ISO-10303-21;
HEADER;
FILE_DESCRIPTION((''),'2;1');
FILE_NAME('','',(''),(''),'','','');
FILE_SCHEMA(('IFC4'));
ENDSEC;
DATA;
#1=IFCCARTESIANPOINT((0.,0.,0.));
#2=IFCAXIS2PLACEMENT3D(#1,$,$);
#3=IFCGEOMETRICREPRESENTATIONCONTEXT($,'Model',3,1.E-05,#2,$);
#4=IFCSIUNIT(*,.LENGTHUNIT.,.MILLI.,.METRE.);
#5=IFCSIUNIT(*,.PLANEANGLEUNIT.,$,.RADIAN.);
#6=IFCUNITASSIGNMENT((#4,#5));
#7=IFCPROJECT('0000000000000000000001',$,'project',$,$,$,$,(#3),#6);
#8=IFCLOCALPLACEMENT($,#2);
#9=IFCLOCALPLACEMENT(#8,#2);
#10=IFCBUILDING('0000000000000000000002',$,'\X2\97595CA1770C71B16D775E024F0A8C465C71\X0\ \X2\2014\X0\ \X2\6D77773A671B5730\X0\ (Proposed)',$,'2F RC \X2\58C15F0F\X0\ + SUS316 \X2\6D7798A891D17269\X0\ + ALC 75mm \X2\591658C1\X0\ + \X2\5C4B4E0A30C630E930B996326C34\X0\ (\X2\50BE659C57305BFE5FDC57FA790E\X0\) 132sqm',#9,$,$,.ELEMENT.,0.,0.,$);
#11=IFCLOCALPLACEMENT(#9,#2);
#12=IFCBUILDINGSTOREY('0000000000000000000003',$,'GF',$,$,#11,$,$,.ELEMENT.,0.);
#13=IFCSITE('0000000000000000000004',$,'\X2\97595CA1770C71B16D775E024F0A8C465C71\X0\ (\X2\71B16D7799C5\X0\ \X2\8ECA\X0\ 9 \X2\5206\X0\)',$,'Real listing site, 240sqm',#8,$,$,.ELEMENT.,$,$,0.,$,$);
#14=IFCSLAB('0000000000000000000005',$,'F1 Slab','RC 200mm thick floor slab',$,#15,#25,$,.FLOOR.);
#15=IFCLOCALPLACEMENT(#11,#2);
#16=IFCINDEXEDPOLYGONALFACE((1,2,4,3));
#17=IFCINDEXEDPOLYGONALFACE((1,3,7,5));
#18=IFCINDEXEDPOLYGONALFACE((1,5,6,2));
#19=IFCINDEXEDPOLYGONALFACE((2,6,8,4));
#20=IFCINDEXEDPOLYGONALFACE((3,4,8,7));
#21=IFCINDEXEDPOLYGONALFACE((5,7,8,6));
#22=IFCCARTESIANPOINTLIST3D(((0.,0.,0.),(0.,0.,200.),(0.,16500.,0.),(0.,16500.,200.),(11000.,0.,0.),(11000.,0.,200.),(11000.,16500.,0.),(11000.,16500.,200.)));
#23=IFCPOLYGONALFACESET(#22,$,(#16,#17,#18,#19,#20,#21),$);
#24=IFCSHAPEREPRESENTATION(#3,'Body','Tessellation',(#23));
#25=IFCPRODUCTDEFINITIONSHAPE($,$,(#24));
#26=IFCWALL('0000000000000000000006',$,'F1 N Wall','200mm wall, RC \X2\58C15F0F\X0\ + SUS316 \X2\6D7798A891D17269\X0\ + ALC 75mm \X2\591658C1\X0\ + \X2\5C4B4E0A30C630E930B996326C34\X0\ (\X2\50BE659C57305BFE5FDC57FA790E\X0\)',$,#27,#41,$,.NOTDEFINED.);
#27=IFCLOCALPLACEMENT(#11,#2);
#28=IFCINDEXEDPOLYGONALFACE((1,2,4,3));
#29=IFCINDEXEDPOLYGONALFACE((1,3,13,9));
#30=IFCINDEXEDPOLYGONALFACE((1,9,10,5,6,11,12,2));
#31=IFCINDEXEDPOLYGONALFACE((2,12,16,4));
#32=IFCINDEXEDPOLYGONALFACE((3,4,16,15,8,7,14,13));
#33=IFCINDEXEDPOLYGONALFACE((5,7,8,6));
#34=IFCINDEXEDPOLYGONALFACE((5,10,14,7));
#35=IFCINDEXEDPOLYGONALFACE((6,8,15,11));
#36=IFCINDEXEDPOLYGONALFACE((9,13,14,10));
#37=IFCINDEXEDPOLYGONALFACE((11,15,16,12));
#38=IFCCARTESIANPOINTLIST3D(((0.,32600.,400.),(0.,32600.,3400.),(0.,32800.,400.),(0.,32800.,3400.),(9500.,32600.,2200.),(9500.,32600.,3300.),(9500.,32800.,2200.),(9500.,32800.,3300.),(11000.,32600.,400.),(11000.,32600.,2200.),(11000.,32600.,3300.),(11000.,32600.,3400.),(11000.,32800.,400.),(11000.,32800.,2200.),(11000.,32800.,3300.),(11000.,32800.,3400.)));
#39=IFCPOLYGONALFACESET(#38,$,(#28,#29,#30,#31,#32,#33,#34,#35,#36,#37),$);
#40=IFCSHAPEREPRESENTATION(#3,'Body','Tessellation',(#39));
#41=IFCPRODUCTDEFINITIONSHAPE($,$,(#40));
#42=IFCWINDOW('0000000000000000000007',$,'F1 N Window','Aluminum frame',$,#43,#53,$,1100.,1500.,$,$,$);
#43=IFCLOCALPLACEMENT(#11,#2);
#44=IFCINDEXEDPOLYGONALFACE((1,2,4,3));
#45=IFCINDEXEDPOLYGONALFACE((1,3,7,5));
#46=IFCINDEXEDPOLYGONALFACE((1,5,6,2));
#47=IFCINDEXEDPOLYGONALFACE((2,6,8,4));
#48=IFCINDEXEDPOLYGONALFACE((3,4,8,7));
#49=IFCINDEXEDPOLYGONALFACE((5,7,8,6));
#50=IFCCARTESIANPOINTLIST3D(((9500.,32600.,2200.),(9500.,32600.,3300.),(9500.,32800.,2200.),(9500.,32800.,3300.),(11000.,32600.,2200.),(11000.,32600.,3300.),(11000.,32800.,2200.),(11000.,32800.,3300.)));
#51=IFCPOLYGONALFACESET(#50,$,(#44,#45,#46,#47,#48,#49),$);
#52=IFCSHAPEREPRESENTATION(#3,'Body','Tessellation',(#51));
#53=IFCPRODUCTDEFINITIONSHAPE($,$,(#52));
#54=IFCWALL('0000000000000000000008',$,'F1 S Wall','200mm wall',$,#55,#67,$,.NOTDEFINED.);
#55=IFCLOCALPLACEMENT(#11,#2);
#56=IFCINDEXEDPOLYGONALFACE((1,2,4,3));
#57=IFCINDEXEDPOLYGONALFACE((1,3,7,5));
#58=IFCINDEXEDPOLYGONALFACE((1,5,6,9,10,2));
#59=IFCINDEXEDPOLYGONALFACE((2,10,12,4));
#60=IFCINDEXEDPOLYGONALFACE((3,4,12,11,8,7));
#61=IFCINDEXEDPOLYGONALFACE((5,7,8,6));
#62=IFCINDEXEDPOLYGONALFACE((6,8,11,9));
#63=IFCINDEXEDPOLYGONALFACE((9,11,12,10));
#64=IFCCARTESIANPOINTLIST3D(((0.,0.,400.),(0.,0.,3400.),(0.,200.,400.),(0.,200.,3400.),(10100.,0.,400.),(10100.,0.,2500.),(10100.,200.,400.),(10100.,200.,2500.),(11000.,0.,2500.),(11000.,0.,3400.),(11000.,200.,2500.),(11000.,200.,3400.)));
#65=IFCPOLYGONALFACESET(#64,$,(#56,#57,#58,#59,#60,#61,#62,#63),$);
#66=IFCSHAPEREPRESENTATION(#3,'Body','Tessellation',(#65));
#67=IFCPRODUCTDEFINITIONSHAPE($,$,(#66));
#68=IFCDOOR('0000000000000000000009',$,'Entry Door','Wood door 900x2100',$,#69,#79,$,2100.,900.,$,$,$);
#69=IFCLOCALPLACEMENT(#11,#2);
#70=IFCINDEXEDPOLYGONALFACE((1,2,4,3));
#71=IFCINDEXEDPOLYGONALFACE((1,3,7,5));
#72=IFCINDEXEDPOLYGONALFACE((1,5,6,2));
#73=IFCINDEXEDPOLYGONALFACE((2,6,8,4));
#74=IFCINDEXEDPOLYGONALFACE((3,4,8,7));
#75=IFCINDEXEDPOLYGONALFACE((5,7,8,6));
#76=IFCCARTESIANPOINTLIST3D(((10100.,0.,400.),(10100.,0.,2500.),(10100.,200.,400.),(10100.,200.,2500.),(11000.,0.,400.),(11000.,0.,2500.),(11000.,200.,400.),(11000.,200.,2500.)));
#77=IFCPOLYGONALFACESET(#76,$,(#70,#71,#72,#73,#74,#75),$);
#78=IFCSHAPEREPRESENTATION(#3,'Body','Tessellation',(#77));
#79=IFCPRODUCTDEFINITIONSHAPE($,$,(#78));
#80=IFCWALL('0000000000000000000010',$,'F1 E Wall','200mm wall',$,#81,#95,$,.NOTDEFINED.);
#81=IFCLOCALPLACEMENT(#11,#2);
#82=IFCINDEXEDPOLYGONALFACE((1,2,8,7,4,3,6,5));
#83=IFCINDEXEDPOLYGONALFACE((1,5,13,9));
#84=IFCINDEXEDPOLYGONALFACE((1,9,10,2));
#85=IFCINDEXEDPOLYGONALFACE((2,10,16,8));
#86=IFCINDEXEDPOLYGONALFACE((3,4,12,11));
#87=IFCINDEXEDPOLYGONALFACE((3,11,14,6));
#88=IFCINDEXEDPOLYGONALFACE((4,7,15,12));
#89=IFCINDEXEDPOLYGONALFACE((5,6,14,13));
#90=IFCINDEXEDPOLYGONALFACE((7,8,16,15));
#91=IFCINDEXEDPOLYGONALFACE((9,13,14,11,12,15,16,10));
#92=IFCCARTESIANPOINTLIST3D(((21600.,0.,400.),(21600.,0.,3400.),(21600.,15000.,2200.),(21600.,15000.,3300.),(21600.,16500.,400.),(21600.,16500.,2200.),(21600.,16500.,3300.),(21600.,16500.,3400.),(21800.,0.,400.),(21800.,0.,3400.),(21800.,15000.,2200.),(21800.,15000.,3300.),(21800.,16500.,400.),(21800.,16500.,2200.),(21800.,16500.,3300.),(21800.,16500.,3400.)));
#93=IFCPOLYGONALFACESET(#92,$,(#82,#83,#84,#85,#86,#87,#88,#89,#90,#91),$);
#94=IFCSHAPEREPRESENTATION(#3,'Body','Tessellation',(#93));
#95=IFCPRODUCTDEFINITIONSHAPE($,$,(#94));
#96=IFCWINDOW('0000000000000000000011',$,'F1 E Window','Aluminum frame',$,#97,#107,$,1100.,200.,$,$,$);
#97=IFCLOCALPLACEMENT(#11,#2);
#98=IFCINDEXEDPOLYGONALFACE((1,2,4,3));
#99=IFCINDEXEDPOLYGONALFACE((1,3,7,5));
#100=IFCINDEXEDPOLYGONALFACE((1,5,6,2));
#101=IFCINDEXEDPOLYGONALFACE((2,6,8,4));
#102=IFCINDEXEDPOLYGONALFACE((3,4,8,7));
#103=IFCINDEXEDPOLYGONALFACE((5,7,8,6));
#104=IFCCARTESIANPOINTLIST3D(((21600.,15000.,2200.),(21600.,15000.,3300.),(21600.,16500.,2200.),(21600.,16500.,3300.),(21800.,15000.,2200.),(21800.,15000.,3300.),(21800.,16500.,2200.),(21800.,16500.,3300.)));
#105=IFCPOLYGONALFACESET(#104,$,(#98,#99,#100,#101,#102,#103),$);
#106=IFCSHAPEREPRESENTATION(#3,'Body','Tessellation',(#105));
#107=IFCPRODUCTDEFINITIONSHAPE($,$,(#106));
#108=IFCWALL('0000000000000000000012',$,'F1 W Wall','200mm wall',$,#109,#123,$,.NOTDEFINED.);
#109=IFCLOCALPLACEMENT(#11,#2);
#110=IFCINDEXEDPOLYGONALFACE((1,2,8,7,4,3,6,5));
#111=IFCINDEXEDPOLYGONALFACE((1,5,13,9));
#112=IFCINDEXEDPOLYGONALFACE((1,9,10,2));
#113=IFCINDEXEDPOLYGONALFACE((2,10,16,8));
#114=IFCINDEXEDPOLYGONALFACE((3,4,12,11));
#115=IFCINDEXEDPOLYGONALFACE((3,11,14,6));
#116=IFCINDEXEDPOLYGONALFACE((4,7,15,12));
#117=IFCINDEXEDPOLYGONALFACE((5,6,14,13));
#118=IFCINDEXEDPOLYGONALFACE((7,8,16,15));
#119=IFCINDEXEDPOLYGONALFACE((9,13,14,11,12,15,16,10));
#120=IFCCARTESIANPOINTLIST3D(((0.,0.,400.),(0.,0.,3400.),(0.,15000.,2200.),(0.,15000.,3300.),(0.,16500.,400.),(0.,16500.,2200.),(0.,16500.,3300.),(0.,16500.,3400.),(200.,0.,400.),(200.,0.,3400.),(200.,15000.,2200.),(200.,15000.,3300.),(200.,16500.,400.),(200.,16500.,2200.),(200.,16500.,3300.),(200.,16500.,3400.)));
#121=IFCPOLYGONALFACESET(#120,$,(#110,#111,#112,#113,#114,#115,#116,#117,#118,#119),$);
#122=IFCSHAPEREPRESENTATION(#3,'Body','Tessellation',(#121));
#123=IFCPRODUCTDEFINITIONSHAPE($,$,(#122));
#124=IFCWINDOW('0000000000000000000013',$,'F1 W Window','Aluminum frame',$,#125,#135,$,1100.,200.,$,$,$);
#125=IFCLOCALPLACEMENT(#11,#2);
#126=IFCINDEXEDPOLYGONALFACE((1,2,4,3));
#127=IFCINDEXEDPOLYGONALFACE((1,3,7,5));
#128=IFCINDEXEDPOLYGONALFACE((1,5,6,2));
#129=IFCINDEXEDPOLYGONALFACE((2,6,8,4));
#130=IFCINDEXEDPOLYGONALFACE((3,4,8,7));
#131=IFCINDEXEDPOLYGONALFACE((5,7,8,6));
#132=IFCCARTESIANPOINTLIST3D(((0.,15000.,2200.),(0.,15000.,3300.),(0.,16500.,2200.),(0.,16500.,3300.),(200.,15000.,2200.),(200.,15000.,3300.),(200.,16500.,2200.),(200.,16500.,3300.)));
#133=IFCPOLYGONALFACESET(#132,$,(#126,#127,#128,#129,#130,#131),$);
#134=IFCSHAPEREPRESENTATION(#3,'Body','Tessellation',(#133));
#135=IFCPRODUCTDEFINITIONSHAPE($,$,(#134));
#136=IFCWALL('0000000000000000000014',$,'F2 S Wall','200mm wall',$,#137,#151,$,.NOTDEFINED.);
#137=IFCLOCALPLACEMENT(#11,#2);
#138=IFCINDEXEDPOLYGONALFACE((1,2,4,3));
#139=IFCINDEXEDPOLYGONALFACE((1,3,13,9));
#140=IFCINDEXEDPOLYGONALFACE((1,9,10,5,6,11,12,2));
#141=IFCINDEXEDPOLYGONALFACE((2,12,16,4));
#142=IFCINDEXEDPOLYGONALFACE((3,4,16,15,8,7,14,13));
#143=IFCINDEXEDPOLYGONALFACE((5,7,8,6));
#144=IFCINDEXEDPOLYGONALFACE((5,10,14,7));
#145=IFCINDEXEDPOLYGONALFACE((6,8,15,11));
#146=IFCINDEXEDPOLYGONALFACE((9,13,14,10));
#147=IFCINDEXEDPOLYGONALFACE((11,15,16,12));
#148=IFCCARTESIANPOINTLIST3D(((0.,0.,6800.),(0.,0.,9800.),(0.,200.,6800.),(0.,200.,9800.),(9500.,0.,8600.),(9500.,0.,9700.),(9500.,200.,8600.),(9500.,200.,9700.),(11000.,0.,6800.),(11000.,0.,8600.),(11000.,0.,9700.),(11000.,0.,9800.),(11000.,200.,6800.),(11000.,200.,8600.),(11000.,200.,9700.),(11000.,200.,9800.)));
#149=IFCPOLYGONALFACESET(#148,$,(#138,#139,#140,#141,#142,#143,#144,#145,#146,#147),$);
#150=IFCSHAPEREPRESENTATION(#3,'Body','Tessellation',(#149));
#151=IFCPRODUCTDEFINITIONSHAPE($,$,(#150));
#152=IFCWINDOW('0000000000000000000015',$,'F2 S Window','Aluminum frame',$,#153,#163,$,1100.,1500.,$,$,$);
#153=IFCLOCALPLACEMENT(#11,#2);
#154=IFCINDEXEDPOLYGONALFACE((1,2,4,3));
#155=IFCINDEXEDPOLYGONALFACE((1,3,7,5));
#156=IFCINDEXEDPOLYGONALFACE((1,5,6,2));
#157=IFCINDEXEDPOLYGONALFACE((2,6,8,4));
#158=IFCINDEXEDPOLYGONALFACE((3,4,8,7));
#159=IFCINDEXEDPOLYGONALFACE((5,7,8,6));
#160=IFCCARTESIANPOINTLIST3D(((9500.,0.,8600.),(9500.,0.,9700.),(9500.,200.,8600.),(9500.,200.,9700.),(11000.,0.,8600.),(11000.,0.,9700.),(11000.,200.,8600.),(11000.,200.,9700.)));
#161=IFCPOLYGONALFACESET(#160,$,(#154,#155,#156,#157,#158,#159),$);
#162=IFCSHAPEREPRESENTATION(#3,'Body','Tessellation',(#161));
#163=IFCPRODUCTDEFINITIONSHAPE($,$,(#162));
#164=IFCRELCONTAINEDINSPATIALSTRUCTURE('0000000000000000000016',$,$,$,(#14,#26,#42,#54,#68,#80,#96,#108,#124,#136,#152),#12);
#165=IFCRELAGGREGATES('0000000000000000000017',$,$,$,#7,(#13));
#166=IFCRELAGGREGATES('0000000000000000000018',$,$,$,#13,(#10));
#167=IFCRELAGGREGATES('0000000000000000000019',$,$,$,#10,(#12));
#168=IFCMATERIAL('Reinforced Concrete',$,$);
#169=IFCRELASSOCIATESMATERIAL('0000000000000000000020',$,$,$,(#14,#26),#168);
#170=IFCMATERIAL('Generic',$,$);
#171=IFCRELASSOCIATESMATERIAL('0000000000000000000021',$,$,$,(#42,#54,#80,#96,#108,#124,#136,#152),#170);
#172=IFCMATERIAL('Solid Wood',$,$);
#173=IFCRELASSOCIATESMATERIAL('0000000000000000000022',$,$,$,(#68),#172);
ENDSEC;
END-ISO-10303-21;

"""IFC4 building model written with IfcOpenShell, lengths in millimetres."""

from ifc_helpers import new_model, si_unit, frame, frame_2d, origin, place, context, project, spatial, rectangle, extrude, material, element, fill, save


model = new_model("IFC4")

# Units and contexts
model_context = context("Model", 3, precision=1e-05, world=origin())
ifc_project = project(units=[si_unit("LENGTHUNIT", "METRE", prefix="MILLI"), si_unit("PLANEANGLEUNIT", "RADIAN")], contexts=[model_context])

# Site, building, storey
site_placement = place(None, origin())
site = spatial("IfcSite", under=ifc_project, at=site_placement, Name="静岡県熱海市伊豆山 (熱海駅 車 9 分)", ObjectType="Real listing site, 240sqm", CompositionType="ELEMENT", RefElevation=0.0)
building_placement = place(site_placement, origin())
building = spatial("IfcBuilding", under=site, at=building_placement, Name="静岡県熱海市伊豆山 — 海眺望地 (Proposed)", ObjectType="2F RC 壁式 + SUS316 海風金物 + ALC 75mm 外壁 + 屋上テラス防水 (傾斜地対応基礎) 132sqm", CompositionType="ELEMENT", ElevationOfRefHeight=0.0, ElevationOfTerrain=0.0)
storey_placement = place(building_placement, origin())
storey = spatial("IfcBuildingStorey", under=building, at=storey_placement, Name="GF", CompositionType="ELEMENT", Elevation=0.0)

# Slab
ifc_material_1 = material(Name="Reinforced Concrete")
slab_1_placement = place(storey_placement, origin())
element("IfcSlab", 1, at=slab_1_placement, inside=storey, material=ifc_material_1, Name="F1 Slab", Description="RC 200mm thick floor slab", PredefinedType="FLOOR", context=model_context, shape_type="SweptSolid", body=[
    extrude(rectangle(XDim=11000.0, YDim=16500.0, at=frame_2d((5500.0, 8250.0))), origin(), (0.0, 0.0, 1.0), 200.0),
])

# Wall, opening, window
wall_1_placement = place(storey_placement, frame((0.0, 16300.0, 200.0)))
wall_1 = element("IfcWall", 2, at=wall_1_placement, inside=storey, material=ifc_material_1, Name="F1 N Wall", Description="200mm wall, RC 壁式 + SUS316 海風金物 + ALC 75mm 外壁 + 屋上テラス防水 (傾斜地対応基礎)", PredefinedType="NOTDEFINED", context=model_context, shape_type="SweptSolid", body=[
    extrude(rectangle(XDim=11000.0, YDim=200.0, at=frame_2d((5500.0, 100.0))), frame((0.0, 16300.0, 200.0)), (0.0, 0.0, 1.0), 3000.0),
])
opening_1_placement = place(storey_placement, frame((4750.0, 16300.0, 1100.0)))
opening_1 = element("IfcOpeningElement", 3, at=opening_1_placement, cuts=wall_1, PredefinedType="NOTDEFINED", context=model_context, shape_type="SweptSolid", body=[
    extrude(rectangle(XDim=1500.0, YDim=200.0, at=frame_2d((750.0, 100.0))), frame((4750.0, 16300.0, 1100.0)), (0.0, 0.0, 1.0), 1100.0),
])
ifc_material_2 = material(Name="Generic")
window_1_placement = place(storey_placement, frame((4750.0, 16300.0, 1100.0)))
window_1 = element("IfcWindow", 4, at=window_1_placement, inside=storey, material=ifc_material_2, Name="F1 N Window", Description="Aluminum frame", OverallHeight=1100.0, OverallWidth=1500.0, context=model_context, shape_type="SweptSolid", body=[
    extrude(rectangle(XDim=1500.0, YDim=200.0, at=frame_2d((750.0, 100.0))), frame((4750.0, 16300.0, 1100.0)), (0.0, 0.0, 1.0), 1100.0),
])
fill(opening_1, window_1)

# Wall, opening, door
wall_2_placement = place(storey_placement, frame((0.0, 0.0, 200.0)))
wall_2 = element("IfcWall", 5, at=wall_2_placement, inside=storey, material=ifc_material_2, Name="F1 S Wall", Description="200mm wall", PredefinedType="NOTDEFINED", context=model_context, shape_type="SweptSolid", body=[
    extrude(rectangle(XDim=11000.0, YDim=200.0, at=frame_2d((5500.0, 100.0))), frame((0.0, 0.0, 200.0)), (0.0, 0.0, 1.0), 3000.0),
])
opening_2_placement = place(storey_placement, frame((5050.0, 0.0, 200.0)))
opening_2 = element("IfcOpeningElement", 6, at=opening_2_placement, cuts=wall_2, PredefinedType="NOTDEFINED", context=model_context, shape_type="SweptSolid", body=[
    extrude(rectangle(XDim=900.0, YDim=200.0, at=frame_2d((450.0, 100.0))), frame((5050.0, 0.0, 200.0)), (0.0, 0.0, 1.0), 2100.0),
])
ifc_material_3 = material(Name="Solid Wood")
door_placement = place(storey_placement, frame((5050.0, 0.0, 200.0)))
door = element("IfcDoor", 7, at=door_placement, inside=storey, material=ifc_material_3, Name="Entry Door", Description="Wood door 900x2100", OverallHeight=2100.0, OverallWidth=900.0, context=model_context, shape_type="SweptSolid", body=[
    extrude(rectangle(XDim=900.0, YDim=200.0, at=frame_2d((450.0, 100.0))), frame((5050.0, 0.0, 200.0)), (0.0, 0.0, 1.0), 2100.0),
])
fill(opening_2, door)

# Walls, openings, windows
wall_3_placement = place(storey_placement, frame((10800.0, 0.0, 200.0)))
wall_3 = element("IfcWall", 8, at=wall_3_placement, inside=storey, material=ifc_material_2, Name="F1 E Wall", Description="200mm wall", PredefinedType="NOTDEFINED", context=model_context, shape_type="SweptSolid", body=[
    extrude(rectangle(XDim=200.0, YDim=16500.0, at=frame_2d((100.0, 8250.0))), frame((10800.0, 0.0, 200.0)), (0.0, 0.0, 1.0), 3000.0),
])
opening_3_placement = place(storey_placement, frame((10800.0, 7500.0, 1100.0)))
opening_3 = element("IfcOpeningElement", 9, at=opening_3_placement, cuts=wall_3, PredefinedType="NOTDEFINED", context=model_context, shape_type="SweptSolid", body=[
    extrude(rectangle(XDim=200.0, YDim=1500.0, at=frame_2d((100.0, 750.0))), frame((10800.0, 7500.0, 1100.0)), (0.0, 0.0, 1.0), 1100.0),
])
window_2_placement = place(storey_placement, frame((10800.0, 7500.0, 1100.0)))
window_2 = element("IfcWindow", 10, at=window_2_placement, inside=storey, material=ifc_material_2, Name="F1 E Window", Description="Aluminum frame", OverallHeight=1100.0, OverallWidth=200.0, context=model_context, shape_type="SweptSolid", body=[
    extrude(rectangle(XDim=200.0, YDim=1500.0, at=frame_2d((100.0, 750.0))), frame((10800.0, 7500.0, 1100.0)), (0.0, 0.0, 1.0), 1100.0),
])
fill(opening_3, window_2)
wall_4_placement = place(storey_placement, frame((0.0, 0.0, 200.0)))
wall_4 = element("IfcWall", 11, at=wall_4_placement, inside=storey, material=ifc_material_2, Name="F1 W Wall", Description="200mm wall", PredefinedType="NOTDEFINED", context=model_context, shape_type="SweptSolid", body=[
    extrude(rectangle(XDim=200.0, YDim=16500.0, at=frame_2d((100.0, 8250.0))), frame((0.0, 0.0, 200.0)), (0.0, 0.0, 1.0), 3000.0),
])
opening_4_placement = place(storey_placement, frame((0.0, 7500.0, 1100.0)))
opening_4 = element("IfcOpeningElement", 12, at=opening_4_placement, cuts=wall_4, PredefinedType="NOTDEFINED", context=model_context, shape_type="SweptSolid", body=[
    extrude(rectangle(XDim=200.0, YDim=1500.0, at=frame_2d((100.0, 750.0))), frame((0.0, 7500.0, 1100.0)), (0.0, 0.0, 1.0), 1100.0),
])
window_3_placement = place(storey_placement, frame((0.0, 7500.0, 1100.0)))
window_3 = element("IfcWindow", 13, at=window_3_placement, inside=storey, material=ifc_material_2, Name="F1 W Window", Description="Aluminum frame", OverallHeight=1100.0, OverallWidth=200.0, context=model_context, shape_type="SweptSolid", body=[
    extrude(rectangle(XDim=200.0, YDim=1500.0, at=frame_2d((100.0, 750.0))), frame((0.0, 7500.0, 1100.0)), (0.0, 0.0, 1.0), 1100.0),
])
fill(opening_4, window_3)
wall_5_placement = place(storey_placement, frame((0.0, 0.0, 3400.0)))
wall_5 = element("IfcWall", 14, at=wall_5_placement, inside=storey, material=ifc_material_2, Name="F2 S Wall", Description="200mm wall", PredefinedType="NOTDEFINED", context=model_context, shape_type="SweptSolid", body=[
    extrude(rectangle(XDim=11000.0, YDim=200.0, at=frame_2d((5500.0, 100.0))), frame((0.0, 0.0, 3400.0)), (0.0, 0.0, 1.0), 3000.0),
])
opening_5_placement = place(storey_placement, frame((4750.0, 0.0, 4300.0)))
opening_5 = element("IfcOpeningElement", 15, at=opening_5_placement, cuts=wall_5, PredefinedType="NOTDEFINED", context=model_context, shape_type="SweptSolid", body=[
    extrude(rectangle(XDim=1500.0, YDim=200.0, at=frame_2d((750.0, 100.0))), frame((4750.0, 0.0, 4300.0)), (0.0, 0.0, 1.0), 1100.0),
])
window_4_placement = place(storey_placement, frame((4750.0, 0.0, 4300.0)))
window_4 = element("IfcWindow", 16, at=window_4_placement, inside=storey, material=ifc_material_2, Name="F2 S Window", Description="Aluminum frame", OverallHeight=1100.0, OverallWidth=1500.0, context=model_context, shape_type="SweptSolid", body=[
    extrude(rectangle(XDim=1500.0, YDim=200.0, at=frame_2d((750.0, 100.0))), frame((4750.0, 0.0, 4300.0)), (0.0, 0.0, 1.0), 1100.0),
])
fill(opening_5, window_4)

save(model, "model.ifc")
